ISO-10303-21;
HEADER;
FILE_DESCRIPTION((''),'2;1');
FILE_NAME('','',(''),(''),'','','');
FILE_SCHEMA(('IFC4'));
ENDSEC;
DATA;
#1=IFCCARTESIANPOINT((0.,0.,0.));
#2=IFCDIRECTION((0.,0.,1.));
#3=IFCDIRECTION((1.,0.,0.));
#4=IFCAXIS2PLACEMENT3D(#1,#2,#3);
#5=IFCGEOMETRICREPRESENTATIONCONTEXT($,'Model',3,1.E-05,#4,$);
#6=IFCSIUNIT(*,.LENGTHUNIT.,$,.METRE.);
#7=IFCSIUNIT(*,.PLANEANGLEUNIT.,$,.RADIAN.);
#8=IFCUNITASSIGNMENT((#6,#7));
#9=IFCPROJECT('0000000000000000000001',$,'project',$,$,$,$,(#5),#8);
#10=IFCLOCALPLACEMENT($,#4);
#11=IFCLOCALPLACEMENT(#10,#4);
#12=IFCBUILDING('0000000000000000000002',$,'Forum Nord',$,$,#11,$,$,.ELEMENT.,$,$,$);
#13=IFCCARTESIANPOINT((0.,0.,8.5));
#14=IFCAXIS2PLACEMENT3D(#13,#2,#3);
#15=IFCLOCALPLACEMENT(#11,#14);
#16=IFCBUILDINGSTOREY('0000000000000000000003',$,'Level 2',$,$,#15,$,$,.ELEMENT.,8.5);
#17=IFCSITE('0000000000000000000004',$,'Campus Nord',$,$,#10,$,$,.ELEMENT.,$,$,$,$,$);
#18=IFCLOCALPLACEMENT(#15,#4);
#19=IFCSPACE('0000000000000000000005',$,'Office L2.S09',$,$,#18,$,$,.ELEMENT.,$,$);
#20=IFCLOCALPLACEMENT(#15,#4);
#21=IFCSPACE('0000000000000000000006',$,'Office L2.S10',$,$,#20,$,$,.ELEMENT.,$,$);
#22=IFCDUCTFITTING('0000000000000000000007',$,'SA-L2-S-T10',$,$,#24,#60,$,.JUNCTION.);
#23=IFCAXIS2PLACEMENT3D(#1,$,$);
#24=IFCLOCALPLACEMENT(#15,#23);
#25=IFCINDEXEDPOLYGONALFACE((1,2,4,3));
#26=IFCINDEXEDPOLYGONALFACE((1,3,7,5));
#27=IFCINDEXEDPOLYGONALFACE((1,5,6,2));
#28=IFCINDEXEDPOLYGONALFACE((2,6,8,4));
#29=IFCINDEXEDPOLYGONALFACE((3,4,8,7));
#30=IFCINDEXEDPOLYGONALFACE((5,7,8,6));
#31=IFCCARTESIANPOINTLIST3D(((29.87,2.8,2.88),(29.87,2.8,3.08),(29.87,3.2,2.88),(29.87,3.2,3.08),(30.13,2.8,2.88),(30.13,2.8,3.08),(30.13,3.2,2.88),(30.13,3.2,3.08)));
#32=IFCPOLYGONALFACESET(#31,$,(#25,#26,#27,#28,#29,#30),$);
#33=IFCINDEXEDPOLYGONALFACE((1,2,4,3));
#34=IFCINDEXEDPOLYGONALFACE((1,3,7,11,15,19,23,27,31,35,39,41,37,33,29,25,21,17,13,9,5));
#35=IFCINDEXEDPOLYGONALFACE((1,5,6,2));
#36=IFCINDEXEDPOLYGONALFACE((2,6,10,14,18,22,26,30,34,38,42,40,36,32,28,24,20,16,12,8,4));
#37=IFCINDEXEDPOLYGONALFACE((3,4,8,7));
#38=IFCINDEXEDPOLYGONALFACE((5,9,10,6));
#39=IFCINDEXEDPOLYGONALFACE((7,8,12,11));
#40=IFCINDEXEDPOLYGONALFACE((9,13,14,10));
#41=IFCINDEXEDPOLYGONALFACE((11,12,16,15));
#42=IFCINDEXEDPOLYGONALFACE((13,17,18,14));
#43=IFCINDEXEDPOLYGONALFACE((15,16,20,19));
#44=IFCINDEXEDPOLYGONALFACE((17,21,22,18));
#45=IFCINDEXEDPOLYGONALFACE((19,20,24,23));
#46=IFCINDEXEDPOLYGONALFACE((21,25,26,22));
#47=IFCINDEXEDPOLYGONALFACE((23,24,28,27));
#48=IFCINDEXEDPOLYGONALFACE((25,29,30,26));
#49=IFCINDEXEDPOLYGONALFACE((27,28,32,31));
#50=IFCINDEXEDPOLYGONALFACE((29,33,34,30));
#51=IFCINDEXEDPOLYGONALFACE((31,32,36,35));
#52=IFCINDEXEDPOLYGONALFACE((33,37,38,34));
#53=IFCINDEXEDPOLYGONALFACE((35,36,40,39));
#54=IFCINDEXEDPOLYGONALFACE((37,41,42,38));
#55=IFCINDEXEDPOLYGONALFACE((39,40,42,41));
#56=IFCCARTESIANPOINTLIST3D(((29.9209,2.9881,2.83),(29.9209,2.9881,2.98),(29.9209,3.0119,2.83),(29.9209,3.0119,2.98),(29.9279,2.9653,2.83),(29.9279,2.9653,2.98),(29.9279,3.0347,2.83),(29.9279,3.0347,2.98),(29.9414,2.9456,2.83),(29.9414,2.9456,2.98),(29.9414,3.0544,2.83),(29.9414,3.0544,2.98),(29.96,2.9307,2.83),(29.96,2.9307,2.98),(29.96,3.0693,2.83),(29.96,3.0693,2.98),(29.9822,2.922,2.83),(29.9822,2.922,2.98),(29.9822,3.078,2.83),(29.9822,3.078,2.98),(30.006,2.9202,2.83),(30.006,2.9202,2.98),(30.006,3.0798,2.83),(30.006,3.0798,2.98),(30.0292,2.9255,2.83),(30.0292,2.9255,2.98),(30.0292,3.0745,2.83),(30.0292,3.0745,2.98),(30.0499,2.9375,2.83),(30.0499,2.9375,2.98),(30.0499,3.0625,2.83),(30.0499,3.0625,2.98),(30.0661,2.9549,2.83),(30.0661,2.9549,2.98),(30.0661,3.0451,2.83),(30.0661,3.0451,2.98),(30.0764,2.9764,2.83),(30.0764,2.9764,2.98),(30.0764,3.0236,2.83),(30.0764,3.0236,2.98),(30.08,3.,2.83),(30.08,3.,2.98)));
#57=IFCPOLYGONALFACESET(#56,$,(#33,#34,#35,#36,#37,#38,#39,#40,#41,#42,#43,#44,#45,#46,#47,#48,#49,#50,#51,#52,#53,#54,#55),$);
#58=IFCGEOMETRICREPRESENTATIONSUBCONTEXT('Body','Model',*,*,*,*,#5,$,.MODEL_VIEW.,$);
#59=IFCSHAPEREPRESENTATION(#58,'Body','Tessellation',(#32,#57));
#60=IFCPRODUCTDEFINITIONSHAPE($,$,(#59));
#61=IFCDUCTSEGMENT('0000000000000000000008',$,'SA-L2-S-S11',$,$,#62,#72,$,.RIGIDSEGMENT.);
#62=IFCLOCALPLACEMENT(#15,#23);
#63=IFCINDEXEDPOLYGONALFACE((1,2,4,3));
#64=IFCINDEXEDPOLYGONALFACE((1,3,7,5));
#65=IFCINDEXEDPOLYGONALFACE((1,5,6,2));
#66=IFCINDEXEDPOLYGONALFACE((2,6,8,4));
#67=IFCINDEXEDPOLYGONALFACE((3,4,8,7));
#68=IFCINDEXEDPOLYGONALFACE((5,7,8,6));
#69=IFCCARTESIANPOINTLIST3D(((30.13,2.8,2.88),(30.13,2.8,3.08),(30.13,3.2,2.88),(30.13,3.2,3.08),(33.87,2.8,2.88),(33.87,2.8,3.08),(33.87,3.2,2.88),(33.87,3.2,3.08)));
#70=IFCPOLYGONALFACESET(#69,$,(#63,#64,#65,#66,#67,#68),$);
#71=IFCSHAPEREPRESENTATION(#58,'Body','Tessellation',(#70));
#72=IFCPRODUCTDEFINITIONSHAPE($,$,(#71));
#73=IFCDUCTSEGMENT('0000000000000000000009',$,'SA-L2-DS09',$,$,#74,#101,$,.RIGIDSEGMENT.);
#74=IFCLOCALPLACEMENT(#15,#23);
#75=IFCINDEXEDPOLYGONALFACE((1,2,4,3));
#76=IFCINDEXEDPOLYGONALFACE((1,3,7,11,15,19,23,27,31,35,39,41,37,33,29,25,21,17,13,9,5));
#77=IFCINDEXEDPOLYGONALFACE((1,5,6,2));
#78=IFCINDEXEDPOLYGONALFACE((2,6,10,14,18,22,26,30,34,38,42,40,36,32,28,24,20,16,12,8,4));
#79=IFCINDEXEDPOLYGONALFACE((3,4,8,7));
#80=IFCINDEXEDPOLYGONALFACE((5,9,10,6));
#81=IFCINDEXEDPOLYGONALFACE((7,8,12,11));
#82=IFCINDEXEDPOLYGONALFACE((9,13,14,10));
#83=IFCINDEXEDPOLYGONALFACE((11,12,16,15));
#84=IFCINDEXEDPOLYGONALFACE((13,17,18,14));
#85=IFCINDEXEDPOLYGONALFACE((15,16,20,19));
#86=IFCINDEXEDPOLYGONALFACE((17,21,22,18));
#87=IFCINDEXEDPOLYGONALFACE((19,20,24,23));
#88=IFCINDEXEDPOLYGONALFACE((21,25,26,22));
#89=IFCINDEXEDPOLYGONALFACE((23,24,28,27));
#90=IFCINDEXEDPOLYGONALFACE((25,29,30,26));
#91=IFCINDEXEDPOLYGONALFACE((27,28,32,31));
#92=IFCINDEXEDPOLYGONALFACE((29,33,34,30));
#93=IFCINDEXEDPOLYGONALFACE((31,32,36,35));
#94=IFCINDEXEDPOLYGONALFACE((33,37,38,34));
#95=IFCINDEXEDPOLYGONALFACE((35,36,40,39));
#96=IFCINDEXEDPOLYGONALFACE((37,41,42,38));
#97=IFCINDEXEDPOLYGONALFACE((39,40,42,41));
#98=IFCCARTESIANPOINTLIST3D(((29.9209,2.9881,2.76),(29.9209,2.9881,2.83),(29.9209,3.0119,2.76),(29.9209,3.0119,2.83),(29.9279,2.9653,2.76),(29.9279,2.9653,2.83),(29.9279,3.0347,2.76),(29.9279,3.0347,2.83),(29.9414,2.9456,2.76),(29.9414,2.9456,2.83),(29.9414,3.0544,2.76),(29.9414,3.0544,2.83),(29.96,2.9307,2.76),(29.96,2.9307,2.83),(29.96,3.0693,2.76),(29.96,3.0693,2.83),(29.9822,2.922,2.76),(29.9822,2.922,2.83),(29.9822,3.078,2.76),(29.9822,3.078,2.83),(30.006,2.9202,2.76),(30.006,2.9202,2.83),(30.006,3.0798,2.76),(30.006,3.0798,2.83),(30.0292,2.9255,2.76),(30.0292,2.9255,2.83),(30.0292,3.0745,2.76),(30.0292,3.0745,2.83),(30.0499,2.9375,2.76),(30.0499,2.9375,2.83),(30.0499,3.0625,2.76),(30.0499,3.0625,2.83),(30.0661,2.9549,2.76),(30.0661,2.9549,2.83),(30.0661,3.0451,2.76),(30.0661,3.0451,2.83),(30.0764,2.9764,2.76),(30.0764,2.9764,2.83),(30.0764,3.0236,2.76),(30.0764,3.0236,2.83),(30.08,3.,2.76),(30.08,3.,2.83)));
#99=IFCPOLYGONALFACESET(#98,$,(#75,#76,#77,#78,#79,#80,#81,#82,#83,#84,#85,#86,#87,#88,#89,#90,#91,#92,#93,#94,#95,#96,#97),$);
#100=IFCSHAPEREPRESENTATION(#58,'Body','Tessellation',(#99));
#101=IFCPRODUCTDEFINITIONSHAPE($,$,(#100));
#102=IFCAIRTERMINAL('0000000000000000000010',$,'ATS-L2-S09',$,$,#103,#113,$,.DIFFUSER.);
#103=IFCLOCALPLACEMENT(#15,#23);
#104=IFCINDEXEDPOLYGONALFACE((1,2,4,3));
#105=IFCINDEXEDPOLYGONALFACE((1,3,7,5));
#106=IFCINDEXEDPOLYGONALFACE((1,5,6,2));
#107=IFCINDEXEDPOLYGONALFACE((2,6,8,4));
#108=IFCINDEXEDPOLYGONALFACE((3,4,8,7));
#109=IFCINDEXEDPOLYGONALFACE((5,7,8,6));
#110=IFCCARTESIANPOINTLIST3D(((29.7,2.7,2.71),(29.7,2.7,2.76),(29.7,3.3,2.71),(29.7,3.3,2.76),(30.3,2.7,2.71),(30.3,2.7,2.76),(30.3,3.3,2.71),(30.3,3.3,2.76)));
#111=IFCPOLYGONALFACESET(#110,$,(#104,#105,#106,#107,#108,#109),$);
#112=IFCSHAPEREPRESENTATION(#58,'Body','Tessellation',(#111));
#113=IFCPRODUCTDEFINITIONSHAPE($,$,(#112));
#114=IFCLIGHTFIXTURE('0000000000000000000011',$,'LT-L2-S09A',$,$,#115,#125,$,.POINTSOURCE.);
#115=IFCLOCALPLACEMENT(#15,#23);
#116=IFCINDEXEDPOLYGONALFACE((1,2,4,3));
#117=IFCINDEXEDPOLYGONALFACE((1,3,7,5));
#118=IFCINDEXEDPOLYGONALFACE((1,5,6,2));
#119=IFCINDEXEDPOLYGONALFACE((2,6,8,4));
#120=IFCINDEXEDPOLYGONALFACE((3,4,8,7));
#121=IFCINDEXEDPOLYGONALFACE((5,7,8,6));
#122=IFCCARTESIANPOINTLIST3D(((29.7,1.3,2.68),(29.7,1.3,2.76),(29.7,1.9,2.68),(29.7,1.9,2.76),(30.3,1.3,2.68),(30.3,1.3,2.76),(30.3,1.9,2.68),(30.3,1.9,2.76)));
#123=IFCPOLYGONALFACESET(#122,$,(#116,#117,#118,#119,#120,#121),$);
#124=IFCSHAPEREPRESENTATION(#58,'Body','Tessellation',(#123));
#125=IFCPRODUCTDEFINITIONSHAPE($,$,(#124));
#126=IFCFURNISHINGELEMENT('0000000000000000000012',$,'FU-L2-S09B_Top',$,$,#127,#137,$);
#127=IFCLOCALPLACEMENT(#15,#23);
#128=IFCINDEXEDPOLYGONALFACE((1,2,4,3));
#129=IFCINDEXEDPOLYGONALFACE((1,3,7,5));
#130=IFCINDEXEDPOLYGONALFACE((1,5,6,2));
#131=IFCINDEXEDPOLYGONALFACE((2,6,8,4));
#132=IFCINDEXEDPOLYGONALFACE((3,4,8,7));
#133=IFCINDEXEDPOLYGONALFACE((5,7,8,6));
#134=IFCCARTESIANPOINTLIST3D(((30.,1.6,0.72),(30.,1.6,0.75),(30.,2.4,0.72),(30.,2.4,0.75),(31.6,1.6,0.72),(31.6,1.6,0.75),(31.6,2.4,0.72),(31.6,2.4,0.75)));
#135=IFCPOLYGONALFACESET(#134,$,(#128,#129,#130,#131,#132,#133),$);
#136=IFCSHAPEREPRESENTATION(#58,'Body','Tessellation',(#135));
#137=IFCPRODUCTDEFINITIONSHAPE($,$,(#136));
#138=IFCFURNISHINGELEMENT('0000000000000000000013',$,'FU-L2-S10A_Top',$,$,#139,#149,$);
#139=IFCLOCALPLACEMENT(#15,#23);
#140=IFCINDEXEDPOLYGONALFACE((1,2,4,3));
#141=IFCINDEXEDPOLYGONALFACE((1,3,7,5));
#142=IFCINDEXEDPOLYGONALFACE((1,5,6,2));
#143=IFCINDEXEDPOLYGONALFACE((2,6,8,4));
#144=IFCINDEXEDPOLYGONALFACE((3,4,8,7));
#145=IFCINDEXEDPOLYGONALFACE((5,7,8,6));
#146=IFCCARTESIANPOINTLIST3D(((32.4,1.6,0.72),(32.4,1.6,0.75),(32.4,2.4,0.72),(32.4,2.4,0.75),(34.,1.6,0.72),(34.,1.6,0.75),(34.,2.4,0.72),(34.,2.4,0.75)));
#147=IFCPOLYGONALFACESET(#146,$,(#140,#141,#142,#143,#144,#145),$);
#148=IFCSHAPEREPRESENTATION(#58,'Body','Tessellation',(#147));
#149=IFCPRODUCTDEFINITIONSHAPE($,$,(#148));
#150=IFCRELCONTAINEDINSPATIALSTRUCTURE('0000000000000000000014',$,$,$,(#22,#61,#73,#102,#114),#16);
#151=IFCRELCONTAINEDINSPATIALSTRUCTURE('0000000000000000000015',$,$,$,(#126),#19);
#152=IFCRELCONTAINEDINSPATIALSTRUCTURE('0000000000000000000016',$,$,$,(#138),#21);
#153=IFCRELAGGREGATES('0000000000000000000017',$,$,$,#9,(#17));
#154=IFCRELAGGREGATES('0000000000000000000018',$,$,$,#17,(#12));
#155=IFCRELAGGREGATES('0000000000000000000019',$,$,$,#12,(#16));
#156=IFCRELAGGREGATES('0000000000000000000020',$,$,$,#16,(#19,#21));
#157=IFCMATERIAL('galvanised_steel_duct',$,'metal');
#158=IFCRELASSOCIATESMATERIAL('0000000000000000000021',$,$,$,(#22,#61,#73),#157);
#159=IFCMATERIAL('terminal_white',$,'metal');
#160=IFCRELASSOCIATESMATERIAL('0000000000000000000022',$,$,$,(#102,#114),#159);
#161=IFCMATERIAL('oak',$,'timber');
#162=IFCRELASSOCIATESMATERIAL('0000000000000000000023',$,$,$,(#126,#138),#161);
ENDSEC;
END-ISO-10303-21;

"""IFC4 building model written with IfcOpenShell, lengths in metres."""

from ifc_helpers import new_model, si_unit, frame, frame_2d, origin_with_axes, origin_2d_with_axis, place, context, subcontext, project, spatial, rectangle, circle, extrude, material, element, save


model = new_model("IFC4")

# Units and contexts
model_context = context("Model", 3, precision=1e-05, world=origin_with_axes())
body_context = subcontext(model_context, "Body", "Model", "MODEL_VIEW")
ifc_project = project(units=[si_unit("LENGTHUNIT", "METRE"), si_unit("PLANEANGLEUNIT", "RADIAN")], contexts=[model_context])

# Site, building, storey
site_placement = place(None, origin_with_axes())
site = spatial("IfcSite", under=ifc_project, at=site_placement, Name="Campus Nord", CompositionType="ELEMENT")
building_placement = place(site_placement, origin_with_axes())
building = spatial("IfcBuilding", under=site, at=building_placement, Name="Forum Nord", CompositionType="ELEMENT")
storey_placement = place(building_placement, frame((0.0, 0.0, 8.5), z_axis=(0.0, 0.0, 1.0), x_axis=(1.0, 0.0, 0.0)))
storey = spatial("IfcBuildingStorey", under=building, at=storey_placement, Name="Level 2", CompositionType="ELEMENT", Elevation=8.5)

# Duct fitting
ifc_material_1 = material(Name="galvanised_steel_duct", Category="metal")
duct_fitting_placement = place(storey_placement, frame((29.87, 3.0, 2.98), z_axis=(1.0, 0.0, 0.0), x_axis=(0.0, 1.0, 0.0)))
element("IfcDuctFitting", 1, at=duct_fitting_placement, inside=storey, material=ifc_material_1, Name="SA-L2-S-T10", PredefinedType="JUNCTION", context=body_context, shape_type="SweptSolid", body=[
    extrude(rectangle(XDim=0.4, YDim=0.2, at=origin_2d_with_axis()), origin_with_axes(), (0.0, 0.0, 1.0), 0.26),
    extrude(circle(Radius=0.08, at=origin_2d_with_axis()), frame((0.0, 0.0, 0.13), z_axis=(0.0, -1.0, 0.0), x_axis=(0.0, 0.0, 1.0)), (0.0, 0.0, 1.0), 0.15),
])

# Duct segments
duct_segment_1_placement = place(storey_placement, frame((30.13, 3.0, 2.98), z_axis=(1.0, 0.0, 0.0), x_axis=(0.0, 1.0, 0.0)))
element("IfcDuctSegment", 2, at=duct_segment_1_placement, inside=storey, material=ifc_material_1, Name="SA-L2-S-S11", PredefinedType="RIGIDSEGMENT", context=body_context, shape_type="SweptSolid", body=[
    extrude(rectangle(XDim=0.4, YDim=0.2, at=origin_2d_with_axis()), origin_with_axes(), (0.0, 0.0, 1.0), 3.74),
])
duct_segment_2_placement = place(storey_placement, frame((30.0, 3.0, 2.83), z_axis=(0.0, 0.0, -1.0), x_axis=(1.0, 0.0, 0.0)))
element("IfcDuctSegment", 3, at=duct_segment_2_placement, inside=storey, material=ifc_material_1, Name="SA-L2-DS09", PredefinedType="RIGIDSEGMENT", context=body_context, shape_type="SweptSolid", body=[
    extrude(circle(Radius=0.08, at=origin_2d_with_axis()), origin_with_axes(), (0.0, 0.0, 1.0), 0.07),
])

# Air terminal
ifc_material_2 = material(Name="terminal_white", Category="metal")
air_terminal_placement = place(storey_placement, frame((30.0, 3.0, 2.71), z_axis=(0.0, 0.0, 1.0), x_axis=(1.0, 0.0, 0.0)))
element("IfcAirTerminal", 4, at=air_terminal_placement, inside=storey, material=ifc_material_2, Name="ATS-L2-S09", PredefinedType="DIFFUSER", context=body_context, shape_type="SweptSolid", body=[
    extrude(rectangle(XDim=0.6, YDim=0.6, at=origin_2d_with_axis()), origin_with_axes(), (0.0, 0.0, 1.0), 0.05),
])

# Light fixture
light_fixture_placement = place(storey_placement, frame((30.0, 1.6, 2.68), z_axis=(0.0, 0.0, 1.0), x_axis=(1.0, 0.0, 0.0)))
element("IfcLightFixture", 5, at=light_fixture_placement, inside=storey, material=ifc_material_2, Name="LT-L2-S09A", PredefinedType="POINTSOURCE", context=body_context, shape_type="SweptSolid", body=[
    extrude(rectangle(XDim=0.6, YDim=0.6, at=origin_2d_with_axis()), origin_with_axes(), (0.0, 0.0, 1.0), 0.08),
])

# Shared definitions
space_1_placement = place(storey_placement, origin_with_axes())
space_1 = spatial("IfcSpace", under=storey, at=space_1_placement, Name="Office L2.S09", CompositionType="ELEMENT")

# Furnishing element
ifc_material_3 = material(Name="oak", Category="timber")
furnishing_1_placement = place(storey_placement, frame((30.0, 1.0, 0.0), z_axis=(0.0, 0.0, 1.0), x_axis=(1.0, 0.0, 0.0)))
element("IfcFurnishingElement", 6, at=furnishing_1_placement, inside=space_1, material=ifc_material_3, Name="FU-L2-S09B_Top", context=body_context, shape_type="SweptSolid", body=[
    extrude(rectangle(XDim=1.6, YDim=0.8, at=frame_2d((0.8, 1.0), x_axis=(1.0, 0.0))), frame((0.0, 0.0, 0.72), z_axis=(0.0, 0.0, 1.0), x_axis=(1.0, 0.0, 0.0)), (0.0, 0.0, 1.0), 0.03),
])

# Shared definitions
space_2_placement = place(storey_placement, origin_with_axes())
space_2 = spatial("IfcSpace", under=storey, at=space_2_placement, Name="Office L2.S10", CompositionType="ELEMENT")

# Furnishing element
furnishing_2_placement = place(storey_placement, frame((32.4, 1.0, 0.0), z_axis=(0.0, 0.0, 1.0), x_axis=(1.0, 0.0, 0.0)))
element("IfcFurnishingElement", 7, at=furnishing_2_placement, inside=space_2, material=ifc_material_3, Name="FU-L2-S10A_Top", context=body_context, shape_type="SweptSolid", body=[
    extrude(rectangle(XDim=1.6, YDim=0.8, at=frame_2d((0.8, 1.0), x_axis=(1.0, 0.0))), frame((0.0, 0.0, 0.72), z_axis=(0.0, 0.0, 1.0), x_axis=(1.0, 0.0, 0.0)), (0.0, 0.0, 1.0), 0.03),
])

save(model, "model.ifc")
